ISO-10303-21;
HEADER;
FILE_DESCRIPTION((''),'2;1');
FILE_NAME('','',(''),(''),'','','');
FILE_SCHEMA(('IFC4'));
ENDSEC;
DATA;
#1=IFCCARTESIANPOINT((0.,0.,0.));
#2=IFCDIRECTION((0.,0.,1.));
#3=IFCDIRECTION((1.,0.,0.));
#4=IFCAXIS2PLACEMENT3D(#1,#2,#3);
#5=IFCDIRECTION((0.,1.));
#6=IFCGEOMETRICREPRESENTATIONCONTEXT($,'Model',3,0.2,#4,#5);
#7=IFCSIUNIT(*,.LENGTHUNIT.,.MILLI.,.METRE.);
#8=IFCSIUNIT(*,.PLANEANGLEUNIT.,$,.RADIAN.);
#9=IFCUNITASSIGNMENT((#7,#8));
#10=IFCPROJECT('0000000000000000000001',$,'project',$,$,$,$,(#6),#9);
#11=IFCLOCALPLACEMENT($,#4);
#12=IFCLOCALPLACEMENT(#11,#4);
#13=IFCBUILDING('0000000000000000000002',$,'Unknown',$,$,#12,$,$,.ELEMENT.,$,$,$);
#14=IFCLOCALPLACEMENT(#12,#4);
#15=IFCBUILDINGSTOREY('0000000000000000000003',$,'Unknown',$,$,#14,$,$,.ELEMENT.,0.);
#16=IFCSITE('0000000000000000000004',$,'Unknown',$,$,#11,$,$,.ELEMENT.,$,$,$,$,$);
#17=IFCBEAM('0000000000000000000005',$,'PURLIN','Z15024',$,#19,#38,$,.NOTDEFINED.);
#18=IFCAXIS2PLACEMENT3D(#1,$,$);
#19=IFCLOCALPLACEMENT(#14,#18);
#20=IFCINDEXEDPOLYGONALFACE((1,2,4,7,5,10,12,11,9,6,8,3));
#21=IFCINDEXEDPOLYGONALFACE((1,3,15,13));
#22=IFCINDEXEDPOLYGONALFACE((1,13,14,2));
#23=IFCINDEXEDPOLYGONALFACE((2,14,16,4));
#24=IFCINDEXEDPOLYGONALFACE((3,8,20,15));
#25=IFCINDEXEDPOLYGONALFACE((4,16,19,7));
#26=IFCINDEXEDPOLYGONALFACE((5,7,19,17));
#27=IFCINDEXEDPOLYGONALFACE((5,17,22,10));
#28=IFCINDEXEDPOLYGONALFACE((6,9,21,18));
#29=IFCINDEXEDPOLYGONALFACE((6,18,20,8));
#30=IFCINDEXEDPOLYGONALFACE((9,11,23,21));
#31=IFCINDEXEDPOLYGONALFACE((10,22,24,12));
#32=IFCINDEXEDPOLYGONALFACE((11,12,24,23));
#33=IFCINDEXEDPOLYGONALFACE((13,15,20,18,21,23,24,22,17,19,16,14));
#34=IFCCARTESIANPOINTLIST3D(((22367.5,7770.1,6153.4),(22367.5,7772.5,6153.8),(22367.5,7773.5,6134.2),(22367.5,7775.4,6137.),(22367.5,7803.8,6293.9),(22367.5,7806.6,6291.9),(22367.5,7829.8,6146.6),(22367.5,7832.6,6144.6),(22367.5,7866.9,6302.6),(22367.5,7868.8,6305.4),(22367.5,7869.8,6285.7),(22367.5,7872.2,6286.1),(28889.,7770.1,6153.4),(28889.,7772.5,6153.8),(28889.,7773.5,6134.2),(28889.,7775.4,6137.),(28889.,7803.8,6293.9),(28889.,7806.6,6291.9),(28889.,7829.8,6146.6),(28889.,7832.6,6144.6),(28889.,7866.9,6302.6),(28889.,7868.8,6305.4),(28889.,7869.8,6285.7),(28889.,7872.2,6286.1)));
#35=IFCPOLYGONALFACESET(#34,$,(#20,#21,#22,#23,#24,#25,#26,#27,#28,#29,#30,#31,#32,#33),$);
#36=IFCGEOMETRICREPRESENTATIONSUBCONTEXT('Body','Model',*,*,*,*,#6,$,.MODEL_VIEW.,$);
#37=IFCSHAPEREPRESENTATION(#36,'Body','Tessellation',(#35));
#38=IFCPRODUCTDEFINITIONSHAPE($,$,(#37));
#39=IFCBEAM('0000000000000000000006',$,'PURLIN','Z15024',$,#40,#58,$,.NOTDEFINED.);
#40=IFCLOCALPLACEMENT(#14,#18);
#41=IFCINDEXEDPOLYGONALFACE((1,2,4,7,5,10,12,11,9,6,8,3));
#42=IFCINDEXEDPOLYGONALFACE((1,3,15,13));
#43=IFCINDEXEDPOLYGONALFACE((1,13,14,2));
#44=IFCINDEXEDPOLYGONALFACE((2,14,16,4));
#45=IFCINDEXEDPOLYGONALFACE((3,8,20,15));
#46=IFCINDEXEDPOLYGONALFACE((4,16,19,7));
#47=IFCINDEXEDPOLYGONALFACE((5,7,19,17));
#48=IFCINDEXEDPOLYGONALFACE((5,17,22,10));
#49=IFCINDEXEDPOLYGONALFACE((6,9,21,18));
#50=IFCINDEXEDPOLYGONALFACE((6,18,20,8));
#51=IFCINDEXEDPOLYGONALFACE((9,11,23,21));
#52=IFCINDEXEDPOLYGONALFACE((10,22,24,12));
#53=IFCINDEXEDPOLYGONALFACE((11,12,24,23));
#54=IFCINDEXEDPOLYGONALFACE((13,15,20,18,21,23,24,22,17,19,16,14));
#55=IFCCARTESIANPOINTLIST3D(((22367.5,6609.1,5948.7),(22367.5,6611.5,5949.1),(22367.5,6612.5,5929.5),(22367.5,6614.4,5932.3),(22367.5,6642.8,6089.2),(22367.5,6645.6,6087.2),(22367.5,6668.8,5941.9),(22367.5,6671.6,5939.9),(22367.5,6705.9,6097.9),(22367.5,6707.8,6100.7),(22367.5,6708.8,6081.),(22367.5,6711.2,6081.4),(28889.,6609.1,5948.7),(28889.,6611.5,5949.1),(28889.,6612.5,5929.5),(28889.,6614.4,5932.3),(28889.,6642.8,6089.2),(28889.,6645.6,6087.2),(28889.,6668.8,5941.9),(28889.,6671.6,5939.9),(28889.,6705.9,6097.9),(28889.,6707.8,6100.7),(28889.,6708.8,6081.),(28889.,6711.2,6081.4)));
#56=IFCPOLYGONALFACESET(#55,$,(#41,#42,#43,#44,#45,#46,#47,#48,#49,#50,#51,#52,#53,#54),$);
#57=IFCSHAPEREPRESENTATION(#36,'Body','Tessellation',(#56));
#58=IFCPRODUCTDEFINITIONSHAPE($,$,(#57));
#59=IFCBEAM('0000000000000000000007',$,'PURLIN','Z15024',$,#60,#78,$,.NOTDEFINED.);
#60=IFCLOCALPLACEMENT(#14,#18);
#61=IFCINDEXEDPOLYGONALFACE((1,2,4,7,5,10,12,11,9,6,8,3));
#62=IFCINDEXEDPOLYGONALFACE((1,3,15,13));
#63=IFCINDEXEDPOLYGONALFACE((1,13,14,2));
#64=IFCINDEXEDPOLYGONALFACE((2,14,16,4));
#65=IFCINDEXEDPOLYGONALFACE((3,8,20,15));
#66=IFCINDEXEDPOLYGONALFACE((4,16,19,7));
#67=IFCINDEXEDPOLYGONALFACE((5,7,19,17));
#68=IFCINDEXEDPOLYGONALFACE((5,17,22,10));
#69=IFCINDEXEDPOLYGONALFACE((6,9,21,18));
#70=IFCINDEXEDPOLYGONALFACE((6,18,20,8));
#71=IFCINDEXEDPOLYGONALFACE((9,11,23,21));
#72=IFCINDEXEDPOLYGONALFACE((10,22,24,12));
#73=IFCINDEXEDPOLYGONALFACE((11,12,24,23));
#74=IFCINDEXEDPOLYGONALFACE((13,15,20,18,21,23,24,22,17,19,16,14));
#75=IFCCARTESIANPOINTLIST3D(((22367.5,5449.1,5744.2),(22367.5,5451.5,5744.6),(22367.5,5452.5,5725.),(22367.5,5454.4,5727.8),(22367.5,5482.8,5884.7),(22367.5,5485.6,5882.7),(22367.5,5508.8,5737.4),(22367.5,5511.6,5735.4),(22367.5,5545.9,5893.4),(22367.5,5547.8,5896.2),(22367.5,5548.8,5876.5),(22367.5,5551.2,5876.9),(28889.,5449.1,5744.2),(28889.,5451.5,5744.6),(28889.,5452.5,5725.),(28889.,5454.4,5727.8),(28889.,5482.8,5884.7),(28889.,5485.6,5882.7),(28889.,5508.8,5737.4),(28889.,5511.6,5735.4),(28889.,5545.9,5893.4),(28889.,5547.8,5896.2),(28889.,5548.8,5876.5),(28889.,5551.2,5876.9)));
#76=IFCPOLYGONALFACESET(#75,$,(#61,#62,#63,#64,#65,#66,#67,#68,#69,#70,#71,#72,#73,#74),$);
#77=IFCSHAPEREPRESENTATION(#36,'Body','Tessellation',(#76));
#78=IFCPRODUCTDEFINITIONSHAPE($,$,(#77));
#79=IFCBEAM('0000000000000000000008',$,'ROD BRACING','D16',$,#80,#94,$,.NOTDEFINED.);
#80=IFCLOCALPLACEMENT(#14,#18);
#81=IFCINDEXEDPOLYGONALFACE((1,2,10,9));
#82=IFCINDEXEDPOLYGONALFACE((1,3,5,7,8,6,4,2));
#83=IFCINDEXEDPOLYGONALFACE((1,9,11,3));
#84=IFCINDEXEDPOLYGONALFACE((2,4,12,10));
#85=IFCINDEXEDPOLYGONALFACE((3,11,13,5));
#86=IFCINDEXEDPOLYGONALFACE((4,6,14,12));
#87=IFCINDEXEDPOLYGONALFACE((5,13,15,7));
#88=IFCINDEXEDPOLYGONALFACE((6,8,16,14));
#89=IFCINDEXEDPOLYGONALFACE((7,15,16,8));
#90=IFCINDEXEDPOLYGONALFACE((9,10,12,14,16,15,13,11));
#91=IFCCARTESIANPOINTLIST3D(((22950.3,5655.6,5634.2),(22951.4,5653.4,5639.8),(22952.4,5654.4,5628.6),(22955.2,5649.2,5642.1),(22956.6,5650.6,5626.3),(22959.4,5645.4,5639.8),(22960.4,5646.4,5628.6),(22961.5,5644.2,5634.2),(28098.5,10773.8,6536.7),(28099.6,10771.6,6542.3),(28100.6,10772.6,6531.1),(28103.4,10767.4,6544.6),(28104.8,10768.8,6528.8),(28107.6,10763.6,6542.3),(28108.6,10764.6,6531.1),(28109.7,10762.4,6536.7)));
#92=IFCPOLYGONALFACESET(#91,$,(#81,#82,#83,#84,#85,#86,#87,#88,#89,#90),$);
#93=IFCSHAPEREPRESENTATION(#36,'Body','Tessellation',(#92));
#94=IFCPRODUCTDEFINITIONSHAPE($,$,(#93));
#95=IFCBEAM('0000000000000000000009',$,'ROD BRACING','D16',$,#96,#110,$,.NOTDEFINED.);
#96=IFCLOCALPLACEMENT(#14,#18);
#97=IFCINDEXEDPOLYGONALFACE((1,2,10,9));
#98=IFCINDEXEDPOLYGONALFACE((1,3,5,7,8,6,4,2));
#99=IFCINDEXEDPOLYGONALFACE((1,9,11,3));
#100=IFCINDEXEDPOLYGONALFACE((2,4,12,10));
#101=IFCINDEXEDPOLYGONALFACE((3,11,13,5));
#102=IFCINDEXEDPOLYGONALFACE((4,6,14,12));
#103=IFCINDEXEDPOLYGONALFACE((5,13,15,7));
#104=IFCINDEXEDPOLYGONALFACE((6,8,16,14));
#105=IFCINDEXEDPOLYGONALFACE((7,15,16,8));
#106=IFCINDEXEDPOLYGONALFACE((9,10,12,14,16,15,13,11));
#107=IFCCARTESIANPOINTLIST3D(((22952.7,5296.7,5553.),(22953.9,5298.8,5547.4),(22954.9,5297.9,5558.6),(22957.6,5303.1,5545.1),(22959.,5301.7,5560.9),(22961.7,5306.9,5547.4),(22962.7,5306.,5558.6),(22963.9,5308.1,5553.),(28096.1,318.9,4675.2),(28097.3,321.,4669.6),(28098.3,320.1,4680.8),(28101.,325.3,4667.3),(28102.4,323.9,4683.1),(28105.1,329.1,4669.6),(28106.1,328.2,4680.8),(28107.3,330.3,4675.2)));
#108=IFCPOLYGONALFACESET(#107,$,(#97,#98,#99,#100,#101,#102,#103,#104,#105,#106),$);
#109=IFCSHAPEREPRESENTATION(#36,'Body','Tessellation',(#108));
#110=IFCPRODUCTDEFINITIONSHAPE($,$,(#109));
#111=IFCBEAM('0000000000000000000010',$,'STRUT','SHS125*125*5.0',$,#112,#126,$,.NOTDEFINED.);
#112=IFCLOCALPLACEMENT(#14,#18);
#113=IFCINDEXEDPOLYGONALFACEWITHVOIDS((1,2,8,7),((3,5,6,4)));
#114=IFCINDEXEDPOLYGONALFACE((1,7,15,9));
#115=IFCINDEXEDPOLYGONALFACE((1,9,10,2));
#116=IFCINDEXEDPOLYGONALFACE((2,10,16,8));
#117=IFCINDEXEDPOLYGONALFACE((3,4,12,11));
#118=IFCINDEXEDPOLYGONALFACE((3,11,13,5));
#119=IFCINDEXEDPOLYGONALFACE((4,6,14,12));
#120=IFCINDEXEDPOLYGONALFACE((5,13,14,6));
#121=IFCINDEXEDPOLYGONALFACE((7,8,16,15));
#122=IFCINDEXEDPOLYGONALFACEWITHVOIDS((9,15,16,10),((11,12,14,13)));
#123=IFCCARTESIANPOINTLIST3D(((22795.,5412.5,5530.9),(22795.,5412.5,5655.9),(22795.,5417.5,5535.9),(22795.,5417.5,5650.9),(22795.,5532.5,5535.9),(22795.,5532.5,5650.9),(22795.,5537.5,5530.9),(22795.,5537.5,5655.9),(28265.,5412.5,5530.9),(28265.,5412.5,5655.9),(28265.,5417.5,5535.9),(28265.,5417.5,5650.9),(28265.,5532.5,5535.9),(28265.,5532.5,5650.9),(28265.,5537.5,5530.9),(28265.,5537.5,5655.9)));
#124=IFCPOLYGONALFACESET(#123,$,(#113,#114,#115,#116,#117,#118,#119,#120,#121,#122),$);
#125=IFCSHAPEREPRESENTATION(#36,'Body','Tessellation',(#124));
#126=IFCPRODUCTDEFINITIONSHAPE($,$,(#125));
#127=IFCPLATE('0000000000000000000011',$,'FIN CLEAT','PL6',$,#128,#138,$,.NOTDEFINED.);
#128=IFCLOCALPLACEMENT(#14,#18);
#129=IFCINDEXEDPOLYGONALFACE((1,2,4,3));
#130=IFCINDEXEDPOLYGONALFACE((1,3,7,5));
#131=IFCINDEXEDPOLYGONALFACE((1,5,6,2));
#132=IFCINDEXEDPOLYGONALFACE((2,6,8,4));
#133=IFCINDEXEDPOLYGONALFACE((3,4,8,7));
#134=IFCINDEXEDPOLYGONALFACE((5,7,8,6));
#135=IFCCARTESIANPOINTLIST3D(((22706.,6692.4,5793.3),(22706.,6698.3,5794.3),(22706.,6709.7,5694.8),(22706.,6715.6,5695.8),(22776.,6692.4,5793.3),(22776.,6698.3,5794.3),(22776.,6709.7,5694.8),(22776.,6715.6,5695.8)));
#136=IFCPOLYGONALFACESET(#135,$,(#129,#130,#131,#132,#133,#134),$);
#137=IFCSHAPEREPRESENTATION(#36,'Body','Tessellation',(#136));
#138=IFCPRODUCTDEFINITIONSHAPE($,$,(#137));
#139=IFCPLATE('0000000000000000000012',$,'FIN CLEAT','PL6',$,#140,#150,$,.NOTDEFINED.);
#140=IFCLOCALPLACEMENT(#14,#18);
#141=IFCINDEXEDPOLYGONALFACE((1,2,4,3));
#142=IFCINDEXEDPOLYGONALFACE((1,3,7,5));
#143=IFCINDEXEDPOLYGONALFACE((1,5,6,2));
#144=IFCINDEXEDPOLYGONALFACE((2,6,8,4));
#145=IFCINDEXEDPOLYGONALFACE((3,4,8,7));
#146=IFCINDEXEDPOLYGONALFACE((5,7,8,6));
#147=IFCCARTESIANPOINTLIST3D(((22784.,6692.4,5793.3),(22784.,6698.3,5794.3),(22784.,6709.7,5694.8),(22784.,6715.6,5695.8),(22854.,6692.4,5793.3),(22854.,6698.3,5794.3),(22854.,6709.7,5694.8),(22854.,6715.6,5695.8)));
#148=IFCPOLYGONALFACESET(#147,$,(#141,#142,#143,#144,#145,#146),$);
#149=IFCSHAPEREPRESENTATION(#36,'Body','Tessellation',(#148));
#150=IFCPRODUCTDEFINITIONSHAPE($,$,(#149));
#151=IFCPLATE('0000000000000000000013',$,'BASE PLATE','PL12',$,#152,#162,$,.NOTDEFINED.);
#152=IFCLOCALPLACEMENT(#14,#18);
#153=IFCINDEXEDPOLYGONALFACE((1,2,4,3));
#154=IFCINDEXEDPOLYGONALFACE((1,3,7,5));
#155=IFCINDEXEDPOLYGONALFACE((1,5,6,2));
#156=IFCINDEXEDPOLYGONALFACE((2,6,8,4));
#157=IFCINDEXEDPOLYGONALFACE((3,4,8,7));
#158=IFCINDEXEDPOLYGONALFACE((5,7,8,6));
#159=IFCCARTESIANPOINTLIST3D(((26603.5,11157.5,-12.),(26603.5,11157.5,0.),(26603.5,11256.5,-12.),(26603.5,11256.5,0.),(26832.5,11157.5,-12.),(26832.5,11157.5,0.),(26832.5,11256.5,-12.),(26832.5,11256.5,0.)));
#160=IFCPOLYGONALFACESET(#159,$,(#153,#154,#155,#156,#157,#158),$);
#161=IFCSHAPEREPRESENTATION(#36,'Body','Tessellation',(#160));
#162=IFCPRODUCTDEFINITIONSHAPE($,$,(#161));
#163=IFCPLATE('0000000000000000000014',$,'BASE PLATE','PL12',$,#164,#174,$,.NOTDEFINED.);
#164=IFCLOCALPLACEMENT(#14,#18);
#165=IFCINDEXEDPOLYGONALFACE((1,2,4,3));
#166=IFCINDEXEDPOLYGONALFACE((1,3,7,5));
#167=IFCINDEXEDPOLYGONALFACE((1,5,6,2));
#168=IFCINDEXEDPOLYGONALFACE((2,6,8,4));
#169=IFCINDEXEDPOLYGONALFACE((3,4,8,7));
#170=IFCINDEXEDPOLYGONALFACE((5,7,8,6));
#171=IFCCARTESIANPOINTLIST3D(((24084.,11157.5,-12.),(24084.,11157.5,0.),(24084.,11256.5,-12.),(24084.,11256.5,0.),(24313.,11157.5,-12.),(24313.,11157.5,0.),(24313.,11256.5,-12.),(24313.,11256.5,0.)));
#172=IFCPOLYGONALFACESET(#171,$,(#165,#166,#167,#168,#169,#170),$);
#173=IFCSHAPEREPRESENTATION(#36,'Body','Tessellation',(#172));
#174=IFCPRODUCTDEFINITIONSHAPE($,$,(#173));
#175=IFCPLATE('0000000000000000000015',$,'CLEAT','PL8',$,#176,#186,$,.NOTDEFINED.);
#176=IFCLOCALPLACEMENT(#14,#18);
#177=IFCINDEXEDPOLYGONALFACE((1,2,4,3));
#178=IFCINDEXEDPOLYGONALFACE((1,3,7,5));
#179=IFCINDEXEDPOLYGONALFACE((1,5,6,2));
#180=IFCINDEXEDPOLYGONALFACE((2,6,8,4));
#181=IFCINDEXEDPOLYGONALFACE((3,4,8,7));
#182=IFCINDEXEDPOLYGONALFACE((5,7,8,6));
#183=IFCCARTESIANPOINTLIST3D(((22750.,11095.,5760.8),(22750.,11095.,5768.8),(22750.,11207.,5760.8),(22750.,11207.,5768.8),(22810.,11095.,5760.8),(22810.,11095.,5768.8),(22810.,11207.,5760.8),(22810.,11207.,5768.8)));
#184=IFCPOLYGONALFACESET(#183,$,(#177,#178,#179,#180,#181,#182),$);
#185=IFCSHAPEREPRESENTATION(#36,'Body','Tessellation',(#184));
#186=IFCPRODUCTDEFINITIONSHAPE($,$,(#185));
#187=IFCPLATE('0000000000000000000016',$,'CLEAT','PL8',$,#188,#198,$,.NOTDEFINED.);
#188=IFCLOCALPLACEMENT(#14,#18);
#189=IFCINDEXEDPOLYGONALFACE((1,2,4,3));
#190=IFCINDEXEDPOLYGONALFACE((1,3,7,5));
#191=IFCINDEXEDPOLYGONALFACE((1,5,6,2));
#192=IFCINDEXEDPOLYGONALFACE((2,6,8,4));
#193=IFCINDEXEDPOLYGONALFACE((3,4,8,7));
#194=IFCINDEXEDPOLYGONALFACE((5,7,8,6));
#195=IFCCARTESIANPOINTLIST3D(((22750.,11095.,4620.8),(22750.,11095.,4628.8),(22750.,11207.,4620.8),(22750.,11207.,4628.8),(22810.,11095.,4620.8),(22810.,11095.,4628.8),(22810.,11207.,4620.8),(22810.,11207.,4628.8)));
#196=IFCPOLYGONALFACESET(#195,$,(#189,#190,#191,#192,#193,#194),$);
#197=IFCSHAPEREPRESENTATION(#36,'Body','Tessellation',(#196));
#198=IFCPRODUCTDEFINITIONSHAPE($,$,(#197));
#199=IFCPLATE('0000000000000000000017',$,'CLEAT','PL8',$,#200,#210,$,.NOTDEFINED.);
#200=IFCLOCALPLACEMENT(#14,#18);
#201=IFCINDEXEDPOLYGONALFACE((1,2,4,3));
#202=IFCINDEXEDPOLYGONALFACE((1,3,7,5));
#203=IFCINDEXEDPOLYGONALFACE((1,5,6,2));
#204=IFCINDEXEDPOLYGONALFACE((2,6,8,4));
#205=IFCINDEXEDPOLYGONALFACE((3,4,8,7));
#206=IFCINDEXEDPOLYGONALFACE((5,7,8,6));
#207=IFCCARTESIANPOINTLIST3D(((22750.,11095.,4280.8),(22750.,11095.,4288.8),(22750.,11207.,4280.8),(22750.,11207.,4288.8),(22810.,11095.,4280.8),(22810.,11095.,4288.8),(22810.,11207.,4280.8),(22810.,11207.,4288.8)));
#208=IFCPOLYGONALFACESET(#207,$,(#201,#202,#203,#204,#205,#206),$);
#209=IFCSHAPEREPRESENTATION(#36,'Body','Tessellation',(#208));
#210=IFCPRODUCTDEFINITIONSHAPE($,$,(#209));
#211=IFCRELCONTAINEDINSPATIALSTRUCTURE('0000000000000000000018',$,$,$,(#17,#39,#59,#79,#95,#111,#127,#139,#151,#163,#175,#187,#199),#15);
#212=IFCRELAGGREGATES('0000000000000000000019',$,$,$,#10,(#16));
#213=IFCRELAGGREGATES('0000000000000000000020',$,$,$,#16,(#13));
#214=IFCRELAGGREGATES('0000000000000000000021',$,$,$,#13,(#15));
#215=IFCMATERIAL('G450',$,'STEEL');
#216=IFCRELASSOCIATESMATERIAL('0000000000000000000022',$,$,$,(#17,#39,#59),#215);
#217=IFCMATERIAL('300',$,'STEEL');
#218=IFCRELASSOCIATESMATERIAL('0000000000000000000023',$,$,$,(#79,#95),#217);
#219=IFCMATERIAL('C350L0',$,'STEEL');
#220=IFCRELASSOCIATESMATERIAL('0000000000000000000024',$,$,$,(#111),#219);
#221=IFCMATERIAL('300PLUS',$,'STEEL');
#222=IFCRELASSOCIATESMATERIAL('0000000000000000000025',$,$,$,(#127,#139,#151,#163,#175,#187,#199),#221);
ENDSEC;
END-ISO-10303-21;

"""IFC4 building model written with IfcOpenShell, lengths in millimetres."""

from ifc_helpers import new_model, si_unit, direction, frame, origin_with_axes, place, context, subcontext, project, spatial, line, indexed_curve, outline, extrude, material, element, save


model = new_model("IFC4")

# Units and contexts
model_context = context("Model", 3, precision=0.2, world=origin_with_axes(), true_north=direction((0.0, 1.0)))
body_context = subcontext(model_context, "Body", "Model", "MODEL_VIEW")
ifc_project = project(units=[si_unit("LENGTHUNIT", "METRE", prefix="MILLI"), si_unit("PLANEANGLEUNIT", "RADIAN")], contexts=[model_context])

# Site, building, storey
site_placement = place(None, origin_with_axes())
site = spatial("IfcSite", under=ifc_project, at=site_placement, Name="Unknown", CompositionType="ELEMENT")
building_placement = place(site_placement, origin_with_axes())
building = spatial("IfcBuilding", under=site, at=building_placement, Name="Unknown", CompositionType="ELEMENT")
storey_placement = place(building_placement, origin_with_axes())
storey = spatial("IfcBuildingStorey", under=building, at=storey_placement, Name="Unknown", CompositionType="ELEMENT", Elevation=0.0)

# Shared definitions
ifc_material_1 = material(Name="C350L0", Category="STEEL")

# Shared definitions
ifc_material_2 = material(Name="300PLUS", Category="STEEL")

# Beams
ifc_material_3 = material(Name="G450", Category="STEEL")
for number, where, z_axis, x_axis, name in (
    (1, (22367.5, 7818.2, 6219.3), (0.0, -0.984808, -0.173648), (1.0, 0.0, 0.0), "PURLIN"),
    (2, (22367.5, 6657.2, 6014.6), (0.0, -0.984808, -0.173648), (1.0, 0.0, 0.0), "PURLIN"),
    (3, (22367.5, 5497.2, 5810.1), (0.0, -0.984808, -0.173648), (1.0, 0.0, 0.0), "PURLIN"),
):
    element("IfcBeam", number, at=place(storey_placement, frame(where, z_axis=z_axis, x_axis=x_axis)), inside=storey, material=ifc_material_3, Name=name, Description="Z15024", PredefinedType="NOTDEFINED", context=body_context, shape_type="SolidModel", body=[
        extrude(outline(indexed_curve([(58.8, -76.0), (58.8, -56.5), (56.4, -56.5), (56.4, -73.6), (1.2, -73.6), (1.2, 76.0), (-64.8, 76.0), (-64.8, 56.5), (-62.4, 56.5), (-62.4, 73.6), (-1.2, 73.6), (-1.2, -76.0)], segments=[line(1, 2, 3, 4, 5, 6, 7, 8, 9, 10, 11, 12, 1)])), frame((0.0, 0.0, 0.0), z_axis=(-1.0, 0.0, 0.0), x_axis=(0.0, 0.0, 1.0)), (0.0, 0.0, -1.0), 6521.5),
    ])
ifc_material_4 = material(Name="300", Category="STEEL")
beam_1_placement = place(storey_placement, frame((22955.9, 5649.9, 5634.2), z_axis=(-0.087491, -0.086981, 0.992361), x_axis=(0.703752, 0.699651, 0.123371)))
element("IfcBeam", 4, at=beam_1_placement, inside=storey, material=ifc_material_4, Name="ROD BRACING", Description="D16", PredefinedType="NOTDEFINED", context=body_context, shape_type="SolidModel", body=[
    extrude(outline(indexed_curve([(8.0, 0.0), (5.7, 5.7), (0.0, 8.0), (-5.7, 5.7), (-8.0, 0.0), (-5.7, -5.7), (0.0, -8.0), (5.7, -5.7)], segments=[line(1, 2, 3, 4, 5, 6, 7, 8, 1)])), frame((0.0, 0.0, 0.0), z_axis=(-1.0, 0.0, 0.0), x_axis=(0.0, 0.0, 1.0)), (0.0, 0.0, -1.0), 7315.4),
])
beam_2_placement = place(storey_placement, frame((22958.3, 5302.4, 5553.0), z_axis=(0.087469, -0.084653, 0.992564), x_axis=(0.713237, -0.690273, -0.121725)))
element("IfcBeam", 5, at=beam_2_placement, inside=storey, material=ifc_material_4, Name="ROD BRACING", Description="D16", PredefinedType="NOTDEFINED", context=body_context, shape_type="SolidModel", body=[
    extrude(outline(indexed_curve([(8.0, 0.0), (5.7, 5.7), (0.0, 8.0), (-5.7, 5.7), (-8.0, 0.0), (-5.7, -5.7), (0.0, -8.0), (5.7, -5.7)], segments=[line(1, 2, 3, 4, 5, 6, 7, 8, 1)])), frame((0.0, 0.0, 0.0), z_axis=(-1.0, 0.0, 0.0), x_axis=(0.0, 0.0, 1.0)), (0.0, 0.0, -1.0), 7211.4),
])
beam_3_placement = place(storey_placement, frame((22795.0, 5475.0, 5593.4), z_axis=(0.0, 0.0, 1.0), x_axis=(1.0, 0.0, 0.0)))
element("IfcBeam", 6, at=beam_3_placement, inside=storey, material=ifc_material_1, Name="STRUT", Description="SHS125*125*5.0", PredefinedType="NOTDEFINED", context=body_context, shape_type="SolidModel", body=[
    extrude(outline(indexed_curve([(-62.5, -62.5), (62.5, -62.5), (62.5, 62.5), (-62.5, 62.5)], segments=[line(1, 2, 3, 4, 1)]), holes=[indexed_curve([(-57.5, -57.5), (-57.5, 57.5), (57.5, 57.5), (57.5, -57.5)], segments=[line(1, 2, 3, 4, 1)])]), frame((0.0, 0.0, 0.0), z_axis=(-1.0, 0.0, 0.0), x_axis=(0.0, 0.0, 1.0)), (0.0, 0.0, -1.0), 5470.0),
])

# Plates
for number, where, z_axis, x_axis, name in (
    (7, (22706.0, 6695.4, 5793.8), (0.0, 0.984924, 0.172987), (1.0, 0.0, 0.0), "FIN CLEAT"),
    (8, (22784.0, 6695.4, 5793.8), (0.0, 0.984924, 0.172987), (1.0, 0.0, 0.0), "FIN CLEAT"),
):
    element("IfcPlate", number, at=place(storey_placement, frame(where, z_axis=z_axis, x_axis=x_axis)), inside=storey, material=ifc_material_2, Name=name, Description="PL6", PredefinedType="NOTDEFINED", context=body_context, shape_type="SolidModel", body=[
        extrude(outline(indexed_curve([(0.0, 0.0), (70.0, 0.0), (70.0, 100.0), (0.0, 100.0)], segments=[line(1, 2, 3, 4, 1)])), frame((0.0, 0.0, 3.0), z_axis=(0.0, 0.0, 1.0), x_axis=(1.0, 0.0, 0.0)), (0.0, 0.0, -1.0), 6.0),
    ])
for number, where, z_axis, x_axis, name in (
    (9, (26603.5, 11157.5, -6.0), (0.0, 0.0, 1.0), (1.0, 0.0, 0.0), "BASE PLATE"),
    (10, (24084.0, 11157.5, -6.0), (0.0, 0.0, 1.0), (1.0, 0.0, 0.0), "BASE PLATE"),
):
    element("IfcPlate", number, at=place(storey_placement, frame(where, z_axis=z_axis, x_axis=x_axis)), inside=storey, material=ifc_material_2, Name=name, Description="PL12", PredefinedType="NOTDEFINED", context=body_context, shape_type="SolidModel", body=[
        extrude(outline(indexed_curve([(0.0, 0.0), (229.0, 0.0), (229.0, 99.0), (0.0, 99.0)], segments=[line(1, 2, 3, 4, 1)])), frame((0.0, 0.0, 6.0), z_axis=(0.0, 0.0, 1.0), x_axis=(1.0, 0.0, 0.0)), (0.0, 0.0, -1.0), 12.0),
    ])
for number, where, z_axis, x_axis, name in (
    (11, (22750.0, 11095.0, 5764.8), (0.0, 0.0, 1.0), (1.0, 0.0, 0.0), "CLEAT"),
    (12, (22750.0, 11095.0, 4624.8), (0.0, 0.0, 1.0), (1.0, 0.0, 0.0), "CLEAT"),
    (13, (22750.0, 11095.0, 4284.8), (0.0, 0.0, 1.0), (1.0, 0.0, 0.0), "CLEAT"),
):
    element("IfcPlate", number, at=place(storey_placement, frame(where, z_axis=z_axis, x_axis=x_axis)), inside=storey, material=ifc_material_2, Name=name, Description="PL8", PredefinedType="NOTDEFINED", context=body_context, shape_type="SolidModel", body=[
        extrude(outline(indexed_curve([(0.0, 0.0), (60.0, 0.0), (60.0, 112.0), (0.0, 112.0)], segments=[line(1, 2, 3, 4, 1)])), frame((0.0, 0.0, 4.0), z_axis=(0.0, 0.0, 1.0), x_axis=(1.0, 0.0, 0.0)), (0.0, 0.0, -1.0), 8.0),
    ])

save(model, "model.ifc")
